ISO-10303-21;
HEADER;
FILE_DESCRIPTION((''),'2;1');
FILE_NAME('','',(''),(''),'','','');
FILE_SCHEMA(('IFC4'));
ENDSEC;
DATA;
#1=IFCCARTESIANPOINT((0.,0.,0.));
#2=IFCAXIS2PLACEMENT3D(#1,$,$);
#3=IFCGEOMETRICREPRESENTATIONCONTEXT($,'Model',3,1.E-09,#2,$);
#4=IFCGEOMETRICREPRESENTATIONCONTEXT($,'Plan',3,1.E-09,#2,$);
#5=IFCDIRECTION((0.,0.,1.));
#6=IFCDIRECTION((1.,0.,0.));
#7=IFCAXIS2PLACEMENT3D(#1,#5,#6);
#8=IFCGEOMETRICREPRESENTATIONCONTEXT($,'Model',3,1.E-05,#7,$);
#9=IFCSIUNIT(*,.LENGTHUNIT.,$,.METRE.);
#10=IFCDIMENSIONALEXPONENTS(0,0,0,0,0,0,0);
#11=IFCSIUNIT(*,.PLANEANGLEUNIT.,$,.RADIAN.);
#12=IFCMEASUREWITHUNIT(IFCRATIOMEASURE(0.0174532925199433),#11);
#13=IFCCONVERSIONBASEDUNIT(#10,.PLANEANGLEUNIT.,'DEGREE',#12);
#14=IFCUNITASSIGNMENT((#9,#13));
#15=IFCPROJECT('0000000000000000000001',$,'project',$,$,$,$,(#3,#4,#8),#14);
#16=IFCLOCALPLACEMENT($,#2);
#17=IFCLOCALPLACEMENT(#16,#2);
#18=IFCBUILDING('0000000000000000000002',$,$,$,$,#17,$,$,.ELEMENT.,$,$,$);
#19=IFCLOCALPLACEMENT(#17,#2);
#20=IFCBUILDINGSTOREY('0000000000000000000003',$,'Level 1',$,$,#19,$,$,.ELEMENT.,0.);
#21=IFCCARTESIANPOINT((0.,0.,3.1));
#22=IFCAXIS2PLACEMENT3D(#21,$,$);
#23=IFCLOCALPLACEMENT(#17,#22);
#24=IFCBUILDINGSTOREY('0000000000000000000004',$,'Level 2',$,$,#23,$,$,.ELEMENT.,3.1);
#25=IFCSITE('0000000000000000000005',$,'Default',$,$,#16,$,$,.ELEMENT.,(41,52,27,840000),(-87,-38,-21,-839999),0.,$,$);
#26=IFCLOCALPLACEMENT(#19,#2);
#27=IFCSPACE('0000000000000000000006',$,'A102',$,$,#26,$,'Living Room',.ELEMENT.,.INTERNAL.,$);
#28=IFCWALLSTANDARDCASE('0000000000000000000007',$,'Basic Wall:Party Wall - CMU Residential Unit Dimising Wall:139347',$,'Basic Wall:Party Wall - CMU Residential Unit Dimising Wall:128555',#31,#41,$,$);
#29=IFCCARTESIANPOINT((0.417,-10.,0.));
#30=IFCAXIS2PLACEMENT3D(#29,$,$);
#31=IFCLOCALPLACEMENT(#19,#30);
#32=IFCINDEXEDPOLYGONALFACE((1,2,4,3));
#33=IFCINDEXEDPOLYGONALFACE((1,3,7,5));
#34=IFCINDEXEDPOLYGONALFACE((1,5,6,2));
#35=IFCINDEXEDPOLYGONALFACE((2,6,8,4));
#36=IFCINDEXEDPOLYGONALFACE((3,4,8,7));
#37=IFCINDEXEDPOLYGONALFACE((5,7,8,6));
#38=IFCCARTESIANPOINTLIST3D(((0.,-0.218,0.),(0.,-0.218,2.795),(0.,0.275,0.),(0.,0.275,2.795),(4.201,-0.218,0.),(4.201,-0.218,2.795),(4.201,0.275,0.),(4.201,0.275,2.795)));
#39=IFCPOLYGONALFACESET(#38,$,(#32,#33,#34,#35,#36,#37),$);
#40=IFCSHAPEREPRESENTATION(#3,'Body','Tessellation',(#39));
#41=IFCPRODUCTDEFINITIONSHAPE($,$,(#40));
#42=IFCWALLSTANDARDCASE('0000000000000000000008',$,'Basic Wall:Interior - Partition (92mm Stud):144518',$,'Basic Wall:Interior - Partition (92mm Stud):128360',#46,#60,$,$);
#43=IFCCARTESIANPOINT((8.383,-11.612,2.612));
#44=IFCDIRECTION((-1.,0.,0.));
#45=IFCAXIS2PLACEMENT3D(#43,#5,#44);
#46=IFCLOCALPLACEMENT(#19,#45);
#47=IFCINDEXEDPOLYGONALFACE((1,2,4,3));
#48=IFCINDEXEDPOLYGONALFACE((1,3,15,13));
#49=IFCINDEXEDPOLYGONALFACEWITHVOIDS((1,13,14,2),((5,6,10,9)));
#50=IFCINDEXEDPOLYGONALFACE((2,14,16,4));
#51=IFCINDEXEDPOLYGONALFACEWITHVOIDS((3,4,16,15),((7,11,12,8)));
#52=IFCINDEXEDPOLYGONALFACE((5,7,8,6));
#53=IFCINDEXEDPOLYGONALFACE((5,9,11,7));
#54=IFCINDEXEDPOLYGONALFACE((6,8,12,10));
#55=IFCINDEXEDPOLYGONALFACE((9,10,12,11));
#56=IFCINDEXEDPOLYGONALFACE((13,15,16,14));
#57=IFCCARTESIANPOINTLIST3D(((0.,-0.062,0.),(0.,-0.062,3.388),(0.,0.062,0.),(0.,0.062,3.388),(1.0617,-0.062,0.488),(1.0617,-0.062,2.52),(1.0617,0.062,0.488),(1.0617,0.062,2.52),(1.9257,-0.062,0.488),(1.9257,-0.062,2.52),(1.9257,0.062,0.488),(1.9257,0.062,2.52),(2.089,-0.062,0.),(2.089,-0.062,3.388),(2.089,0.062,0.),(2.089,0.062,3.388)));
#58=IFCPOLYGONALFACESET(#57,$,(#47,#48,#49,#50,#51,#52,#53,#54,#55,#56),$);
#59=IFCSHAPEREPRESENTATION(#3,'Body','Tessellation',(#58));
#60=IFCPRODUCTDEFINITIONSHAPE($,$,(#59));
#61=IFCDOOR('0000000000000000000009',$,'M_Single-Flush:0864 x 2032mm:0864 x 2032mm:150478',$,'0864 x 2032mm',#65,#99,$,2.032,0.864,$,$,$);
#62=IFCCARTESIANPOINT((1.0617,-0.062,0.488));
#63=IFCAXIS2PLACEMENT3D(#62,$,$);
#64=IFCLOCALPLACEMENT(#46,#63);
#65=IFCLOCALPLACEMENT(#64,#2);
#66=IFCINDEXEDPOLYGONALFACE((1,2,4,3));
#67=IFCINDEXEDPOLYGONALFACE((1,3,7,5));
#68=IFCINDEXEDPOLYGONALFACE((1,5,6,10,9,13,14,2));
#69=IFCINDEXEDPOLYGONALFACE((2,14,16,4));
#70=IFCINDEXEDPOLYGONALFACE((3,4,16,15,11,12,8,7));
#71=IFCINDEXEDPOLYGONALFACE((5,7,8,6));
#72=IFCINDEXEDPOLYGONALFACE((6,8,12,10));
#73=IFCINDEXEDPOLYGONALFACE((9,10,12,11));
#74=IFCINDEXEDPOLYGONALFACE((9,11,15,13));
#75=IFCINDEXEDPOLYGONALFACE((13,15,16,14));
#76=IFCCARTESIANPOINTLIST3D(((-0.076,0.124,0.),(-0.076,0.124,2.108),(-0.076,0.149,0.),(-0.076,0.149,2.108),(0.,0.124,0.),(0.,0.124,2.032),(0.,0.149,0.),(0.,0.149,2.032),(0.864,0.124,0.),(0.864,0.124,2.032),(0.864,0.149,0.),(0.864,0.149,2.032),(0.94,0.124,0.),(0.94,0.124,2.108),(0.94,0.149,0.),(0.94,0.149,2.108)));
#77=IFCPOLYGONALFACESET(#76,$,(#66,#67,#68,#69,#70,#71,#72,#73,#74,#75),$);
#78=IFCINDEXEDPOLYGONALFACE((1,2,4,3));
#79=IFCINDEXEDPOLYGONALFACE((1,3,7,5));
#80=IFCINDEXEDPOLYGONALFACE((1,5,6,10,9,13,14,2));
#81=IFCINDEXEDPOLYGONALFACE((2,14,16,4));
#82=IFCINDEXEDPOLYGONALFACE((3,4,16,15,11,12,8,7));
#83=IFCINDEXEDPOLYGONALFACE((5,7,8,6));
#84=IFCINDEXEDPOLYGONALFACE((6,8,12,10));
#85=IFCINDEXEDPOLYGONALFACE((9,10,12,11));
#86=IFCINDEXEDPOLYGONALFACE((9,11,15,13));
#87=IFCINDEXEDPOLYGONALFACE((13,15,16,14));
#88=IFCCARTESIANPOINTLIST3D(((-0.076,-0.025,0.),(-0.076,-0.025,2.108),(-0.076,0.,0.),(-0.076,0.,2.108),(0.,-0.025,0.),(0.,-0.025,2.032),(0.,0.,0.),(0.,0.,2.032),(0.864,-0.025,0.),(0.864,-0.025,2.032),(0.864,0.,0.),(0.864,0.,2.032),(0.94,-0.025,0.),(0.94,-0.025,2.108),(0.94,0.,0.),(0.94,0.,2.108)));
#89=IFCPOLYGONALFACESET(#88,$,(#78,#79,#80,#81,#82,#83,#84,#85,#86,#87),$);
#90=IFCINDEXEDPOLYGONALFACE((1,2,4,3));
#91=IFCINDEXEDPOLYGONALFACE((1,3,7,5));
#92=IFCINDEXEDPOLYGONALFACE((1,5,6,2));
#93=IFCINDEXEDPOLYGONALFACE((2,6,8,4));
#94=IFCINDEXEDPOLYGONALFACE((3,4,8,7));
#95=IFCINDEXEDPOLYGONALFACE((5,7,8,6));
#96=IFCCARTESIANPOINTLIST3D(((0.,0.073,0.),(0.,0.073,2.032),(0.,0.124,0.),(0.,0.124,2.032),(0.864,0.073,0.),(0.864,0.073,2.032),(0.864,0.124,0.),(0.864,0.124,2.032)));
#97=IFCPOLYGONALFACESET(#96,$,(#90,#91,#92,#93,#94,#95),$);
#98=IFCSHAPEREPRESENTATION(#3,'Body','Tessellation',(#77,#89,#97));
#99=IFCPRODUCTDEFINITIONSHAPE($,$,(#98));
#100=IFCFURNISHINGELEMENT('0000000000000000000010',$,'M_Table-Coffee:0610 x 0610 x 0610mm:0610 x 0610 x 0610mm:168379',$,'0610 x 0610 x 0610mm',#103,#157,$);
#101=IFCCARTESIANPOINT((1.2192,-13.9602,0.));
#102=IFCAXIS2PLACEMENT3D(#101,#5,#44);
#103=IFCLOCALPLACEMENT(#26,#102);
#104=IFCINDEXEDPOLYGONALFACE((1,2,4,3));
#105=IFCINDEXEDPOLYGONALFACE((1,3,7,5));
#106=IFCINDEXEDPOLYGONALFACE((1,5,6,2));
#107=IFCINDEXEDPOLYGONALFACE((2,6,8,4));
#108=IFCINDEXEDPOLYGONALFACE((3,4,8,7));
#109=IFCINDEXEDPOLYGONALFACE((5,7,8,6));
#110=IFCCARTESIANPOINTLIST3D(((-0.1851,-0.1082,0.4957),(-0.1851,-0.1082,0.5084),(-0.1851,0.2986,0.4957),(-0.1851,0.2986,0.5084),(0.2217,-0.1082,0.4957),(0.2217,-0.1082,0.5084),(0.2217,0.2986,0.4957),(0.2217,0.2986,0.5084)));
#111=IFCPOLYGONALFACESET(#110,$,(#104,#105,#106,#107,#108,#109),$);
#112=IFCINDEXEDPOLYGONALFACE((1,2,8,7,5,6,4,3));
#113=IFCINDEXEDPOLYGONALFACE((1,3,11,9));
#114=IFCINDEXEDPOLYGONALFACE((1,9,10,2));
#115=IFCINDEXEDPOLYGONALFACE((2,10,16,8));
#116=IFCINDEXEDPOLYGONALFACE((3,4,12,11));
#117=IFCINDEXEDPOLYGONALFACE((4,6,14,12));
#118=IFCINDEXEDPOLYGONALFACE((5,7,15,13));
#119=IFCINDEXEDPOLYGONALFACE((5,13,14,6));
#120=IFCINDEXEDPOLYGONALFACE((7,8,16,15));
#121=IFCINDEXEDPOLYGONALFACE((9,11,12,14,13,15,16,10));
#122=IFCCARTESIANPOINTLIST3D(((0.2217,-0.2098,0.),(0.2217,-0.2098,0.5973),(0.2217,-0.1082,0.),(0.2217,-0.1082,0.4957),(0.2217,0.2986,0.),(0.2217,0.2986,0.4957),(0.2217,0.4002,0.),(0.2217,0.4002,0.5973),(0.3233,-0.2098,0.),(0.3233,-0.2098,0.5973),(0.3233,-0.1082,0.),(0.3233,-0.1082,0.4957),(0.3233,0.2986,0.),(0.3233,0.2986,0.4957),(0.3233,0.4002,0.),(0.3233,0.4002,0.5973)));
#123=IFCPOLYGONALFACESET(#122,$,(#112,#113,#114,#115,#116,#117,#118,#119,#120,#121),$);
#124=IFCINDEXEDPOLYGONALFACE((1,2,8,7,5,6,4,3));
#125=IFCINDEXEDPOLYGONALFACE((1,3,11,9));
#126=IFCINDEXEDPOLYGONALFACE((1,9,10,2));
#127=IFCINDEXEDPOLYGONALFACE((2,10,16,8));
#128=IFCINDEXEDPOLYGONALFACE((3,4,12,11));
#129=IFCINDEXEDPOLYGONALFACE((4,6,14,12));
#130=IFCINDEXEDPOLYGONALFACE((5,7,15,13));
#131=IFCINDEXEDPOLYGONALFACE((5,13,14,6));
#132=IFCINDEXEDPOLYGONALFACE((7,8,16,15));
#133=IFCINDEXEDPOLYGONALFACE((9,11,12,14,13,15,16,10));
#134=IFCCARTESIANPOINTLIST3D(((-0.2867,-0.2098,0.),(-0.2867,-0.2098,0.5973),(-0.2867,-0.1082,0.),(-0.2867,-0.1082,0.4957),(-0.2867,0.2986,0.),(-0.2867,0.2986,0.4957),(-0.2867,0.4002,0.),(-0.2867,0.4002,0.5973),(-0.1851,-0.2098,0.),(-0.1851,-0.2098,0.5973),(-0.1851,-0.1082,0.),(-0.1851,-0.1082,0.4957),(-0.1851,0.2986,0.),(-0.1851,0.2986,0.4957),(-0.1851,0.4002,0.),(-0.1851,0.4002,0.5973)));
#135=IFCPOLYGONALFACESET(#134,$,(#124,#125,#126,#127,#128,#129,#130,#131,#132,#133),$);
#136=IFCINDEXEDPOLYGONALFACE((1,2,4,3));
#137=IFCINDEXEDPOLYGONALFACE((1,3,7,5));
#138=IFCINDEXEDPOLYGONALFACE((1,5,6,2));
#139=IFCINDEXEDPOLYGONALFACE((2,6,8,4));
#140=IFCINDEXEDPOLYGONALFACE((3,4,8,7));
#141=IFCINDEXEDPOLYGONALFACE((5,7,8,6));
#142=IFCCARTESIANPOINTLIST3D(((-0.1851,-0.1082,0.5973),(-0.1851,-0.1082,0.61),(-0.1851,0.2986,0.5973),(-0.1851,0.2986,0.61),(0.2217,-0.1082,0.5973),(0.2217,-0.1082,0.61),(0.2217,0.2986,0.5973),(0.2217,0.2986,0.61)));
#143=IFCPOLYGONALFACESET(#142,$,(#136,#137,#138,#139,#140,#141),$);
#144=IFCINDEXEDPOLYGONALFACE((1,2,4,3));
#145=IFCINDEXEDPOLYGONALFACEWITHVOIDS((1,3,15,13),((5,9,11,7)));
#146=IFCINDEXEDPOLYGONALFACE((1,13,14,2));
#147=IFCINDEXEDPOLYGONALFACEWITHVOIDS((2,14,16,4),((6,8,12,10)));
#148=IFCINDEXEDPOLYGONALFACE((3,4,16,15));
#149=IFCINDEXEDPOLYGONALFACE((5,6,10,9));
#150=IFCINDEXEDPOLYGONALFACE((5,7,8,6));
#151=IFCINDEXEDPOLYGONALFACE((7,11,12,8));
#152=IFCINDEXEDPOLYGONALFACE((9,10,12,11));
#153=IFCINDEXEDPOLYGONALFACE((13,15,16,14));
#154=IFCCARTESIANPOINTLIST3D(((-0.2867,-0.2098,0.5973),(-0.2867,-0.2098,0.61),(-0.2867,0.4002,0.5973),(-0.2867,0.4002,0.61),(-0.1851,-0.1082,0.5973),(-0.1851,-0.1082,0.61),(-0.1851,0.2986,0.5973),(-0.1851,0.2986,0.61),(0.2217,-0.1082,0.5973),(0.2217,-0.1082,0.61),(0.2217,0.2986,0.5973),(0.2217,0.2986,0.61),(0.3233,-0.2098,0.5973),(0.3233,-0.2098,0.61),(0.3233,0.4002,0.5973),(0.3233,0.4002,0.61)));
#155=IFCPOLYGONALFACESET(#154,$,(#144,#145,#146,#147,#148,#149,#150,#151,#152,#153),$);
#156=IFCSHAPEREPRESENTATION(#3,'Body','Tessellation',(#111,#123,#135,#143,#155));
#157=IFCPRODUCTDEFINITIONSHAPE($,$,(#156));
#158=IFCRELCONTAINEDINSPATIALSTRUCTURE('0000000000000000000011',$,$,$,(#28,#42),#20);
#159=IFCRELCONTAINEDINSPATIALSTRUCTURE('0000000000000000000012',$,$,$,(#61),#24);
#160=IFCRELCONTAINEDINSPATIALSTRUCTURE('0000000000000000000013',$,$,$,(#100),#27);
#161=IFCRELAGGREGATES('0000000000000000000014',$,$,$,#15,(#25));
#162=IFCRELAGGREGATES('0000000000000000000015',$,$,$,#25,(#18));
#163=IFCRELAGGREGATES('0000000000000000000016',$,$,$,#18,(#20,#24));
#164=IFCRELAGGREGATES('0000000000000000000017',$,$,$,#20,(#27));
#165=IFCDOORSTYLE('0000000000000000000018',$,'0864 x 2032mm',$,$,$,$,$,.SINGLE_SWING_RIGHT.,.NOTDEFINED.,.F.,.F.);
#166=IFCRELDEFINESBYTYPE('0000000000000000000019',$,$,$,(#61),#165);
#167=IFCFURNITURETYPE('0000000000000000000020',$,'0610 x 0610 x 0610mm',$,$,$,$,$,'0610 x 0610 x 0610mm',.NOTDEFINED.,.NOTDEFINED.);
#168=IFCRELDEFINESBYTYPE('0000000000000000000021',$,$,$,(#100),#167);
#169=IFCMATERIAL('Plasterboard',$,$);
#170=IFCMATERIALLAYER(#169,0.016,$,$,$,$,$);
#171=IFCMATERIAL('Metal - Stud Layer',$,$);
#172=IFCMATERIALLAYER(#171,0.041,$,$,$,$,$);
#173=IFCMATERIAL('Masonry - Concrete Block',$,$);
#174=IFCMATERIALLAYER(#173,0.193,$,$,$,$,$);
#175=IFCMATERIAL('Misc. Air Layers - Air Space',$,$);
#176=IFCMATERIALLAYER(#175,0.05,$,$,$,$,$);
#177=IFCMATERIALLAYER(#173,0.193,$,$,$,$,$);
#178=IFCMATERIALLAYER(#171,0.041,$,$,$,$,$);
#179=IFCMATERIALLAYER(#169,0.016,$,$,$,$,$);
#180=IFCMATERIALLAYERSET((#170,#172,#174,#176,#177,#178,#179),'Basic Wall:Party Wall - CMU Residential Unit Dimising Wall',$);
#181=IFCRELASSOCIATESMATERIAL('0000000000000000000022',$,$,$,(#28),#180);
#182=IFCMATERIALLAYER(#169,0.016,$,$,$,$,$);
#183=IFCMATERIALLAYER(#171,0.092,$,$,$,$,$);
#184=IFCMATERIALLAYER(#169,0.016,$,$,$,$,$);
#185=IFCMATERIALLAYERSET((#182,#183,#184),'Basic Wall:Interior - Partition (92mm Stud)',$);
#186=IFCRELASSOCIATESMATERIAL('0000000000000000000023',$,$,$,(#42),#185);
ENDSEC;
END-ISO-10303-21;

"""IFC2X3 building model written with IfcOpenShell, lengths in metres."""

from ifc_helpers import new_model, entity, si_unit, converted_unit, frame, frame_2d, origin, origin_with_axes, origin_2d_with_axis, place, context, project, spatial, polyline, rectangle, outline, extrude, clip, bounded_halfspace, source, transform, mapped, material, layer, layer_set, layer_usage, type_object, type_shapes, element, fill, save


model = new_model("IFC2X3")

# Units and contexts
model_context_1 = context("Model", 3, precision=1e-09, world=origin())
plan_context = context("Plan", 3, precision=1e-09, world=origin())
model_context_2 = context("Model", 3, precision=1e-05, world=origin_with_axes())
ifc_project = project(units=[si_unit("LENGTHUNIT", "METRE"), converted_unit("PLANEANGLEUNIT", "DEGREE", entity("IfcRatioMeasure", 0.0174532925199433), si_unit("PLANEANGLEUNIT", "RADIAN"), dimensions=[0, 0, 0, 0, 0, 0, 0])], contexts=[model_context_1, plan_context, model_context_2])

# Site, building, storey
site_placement = place(None, origin())
site = spatial("IfcSite", under=ifc_project, at=site_placement, Name="Default", CompositionType="ELEMENT", RefLatitude=(41, 52, 27, 840000), RefLongitude=(-87, -38, -21, -839999), RefElevation=0.0)
building_placement = place(site_placement, origin())
building = spatial("IfcBuilding", under=site, at=building_placement, CompositionType="ELEMENT")
storey_1_placement = place(building_placement, origin())
storey_1 = spatial("IfcBuildingStorey", under=building, at=storey_1_placement, Name="Level 1", CompositionType="ELEMENT", Elevation=0.0)

# Shared definitions
ifc_material_1 = material(Name="Misc. Air Layers - Air Space")
ifc_material_2 = material(Name="Masonry - Concrete Block")
ifc_material_3 = material(Name="Metal - Stud Layer")
ifc_material_4 = material(Name="Plasterboard")

# Wall
ifc_layer_1 = layer(ifc_material_4, 0.016)
ifc_layer_2 = layer(ifc_material_3, 0.041)
ifc_layer_3 = layer(ifc_material_2, 0.193)
ifc_layer_4 = layer(ifc_material_1, 0.05)
ifc_layer_5 = layer(ifc_material_2, 0.193)
ifc_layer_6 = layer(ifc_material_3, 0.041)
ifc_layer_7 = layer(ifc_material_4, 0.016)
ifc_layer_set_1 = layer_set([ifc_layer_1, ifc_layer_2, ifc_layer_3, ifc_layer_4, ifc_layer_5, ifc_layer_6, ifc_layer_7], Name="Basic Wall:Party Wall - CMU Residential Unit Dimising Wall")
ifc_layer_usage_1 = layer_usage(ifc_layer_set_1, "AXIS2", "NEGATIVE", 0.275)
wall_1_placement = place(storey_1_placement, frame((0.417, -10.0, 0.0)))
element("IfcWallStandardCase", 1, at=wall_1_placement, inside=storey_1, material=ifc_layer_usage_1, Name="Basic Wall:Party Wall - CMU Residential Unit Dimising Wall:139347", ObjectType="Basic Wall:Party Wall - CMU Residential Unit Dimising Wall:128555", context=model_context_1, shape_type="Clipping", body=[
    clip(clip(extrude(rectangle(XDim=4.201, YDim=0.55, at=frame_2d((2.1005, 0.0), x_axis=(-1.0, 0.0))), origin(), (0.0, 0.0, 1.0), 2.795), bounded_halfspace(frame((0.0, -0.218, 0.0), z_axis=(0.0, 1.0, 0.0), x_axis=(-1.0, 0.0, 0.0)), True, frame((0.0, -0.218, 0.0), z_axis=(0.0, 1.0, 0.0), x_axis=(-1.0, 0.0, 0.0)), polyline([(0.0, 0.0), (0.0, 2.795), (-4.201, 2.795), (-4.201, 0.0), (0.0, 0.0)]))), bounded_halfspace(frame((4.201, 0.275, 0.0), z_axis=(-1.0, 0.0, 0.0), x_axis=(0.0, -1.0, 0.0)), True, frame((4.201, 0.275, 0.0), z_axis=(-1.0, 0.0, 0.0), x_axis=(0.0, -1.0, 0.0)), polyline([(0.0, 0.0), (0.493, 0.0), (0.493, 2.795), (0.0, 2.795), (0.0, 0.0)]))),
])

# Shared definitions
ifc_layer_8 = layer(ifc_material_4, 0.016)
ifc_layer_9 = layer(ifc_material_3, 0.092)
ifc_layer_10 = layer(ifc_material_4, 0.016)
ifc_layer_set_2 = layer_set([ifc_layer_8, ifc_layer_9, ifc_layer_10], Name="Basic Wall:Interior - Partition (92mm Stud)")

# Wall, opening
ifc_layer_usage_2 = layer_usage(ifc_layer_set_2, "AXIS2", "NEGATIVE", 0.062)
wall_2_placement = place(storey_1_placement, frame((8.383, -11.612, 2.612), z_axis=(0.0, 0.0, 1.0), x_axis=(-1.0, 0.0, 0.0)))
wall_2 = element("IfcWallStandardCase", 2, at=wall_2_placement, inside=storey_1, material=ifc_layer_usage_2, Name="Basic Wall:Interior - Partition (92mm Stud):144518", ObjectType="Basic Wall:Interior - Partition (92mm Stud):128360", context=model_context_1, shape_type="SweptSolid", body=[
    extrude(rectangle(XDim=2.089, YDim=0.124, at=frame_2d((1.0445, 0.0), x_axis=(-1.0, 0.0))), origin(), (0.0, 0.0, 1.0), 3.388),
])
opening_1_placement = place(wall_2_placement, frame((1.0617, -0.062, 0.488)))
opening_1 = element("IfcOpeningElement", 3, at=opening_1_placement, cuts=wall_2, ObjectType="Opening", context=model_context_1, shape_type="SweptSolid", body=[
    extrude(rectangle(XDim=0.864, YDim=2.032, at=frame_2d((1.016, 0.432), x_axis=(0.0, 1.0))), frame((0.0, 0.0, 0.0), z_axis=(0.0, 1.0, 0.0), x_axis=(0.0, 0.0, 1.0)), (0.0, 0.0, 1.0), 0.124),
])

# Shared definitions
storey_2_placement = place(building_placement, frame((0.0, 0.0, 3.1)))
storey_2 = spatial("IfcBuildingStorey", under=building, at=storey_2_placement, Name="Level 2", CompositionType="ELEMENT", Elevation=3.1)

# Door
door_style_1 = type_object("IfcDoorStyle", Name="0864 x 2032mm", ConstructionType="NOTDEFINED", OperationType="SINGLE_SWING_RIGHT", ParameterTakesPrecedence=False, Sizeable=False)
shared_shape_1 = source(origin(), model_context_1, "Body", "SweptSolid", [
    extrude(outline(polyline([(-0.508, -1.073), (0.508, -1.073), (0.508, 1.035), (0.432, 1.035), (0.432, -0.997), (-0.432, -0.997), (-0.432, 1.035), (-0.508, 1.035), (-0.508, -1.073)])), frame((0.432, 0.124, 1.035), z_axis=(0.0, 1.0, 0.0), x_axis=(1.0, 0.0, 0.0)), (0.0, 0.0, 1.0), 0.025),
    extrude(outline(polyline([(-1.073, -0.508), (1.035, -0.508), (1.035, -0.432), (-0.997, -0.432), (-0.997, 0.432), (1.035, 0.432), (1.035, 0.508), (-1.073, 0.508), (-1.073, -0.508)])), frame((0.432, -0.025, 1.035), z_axis=(0.0, 1.0, 0.0), x_axis=(0.0, 0.0, -1.0)), (0.0, 0.0, 1.0), 0.025),
    extrude(rectangle(XDim=0.051, YDim=0.864, at=origin_2d_with_axis()), frame((0.432, 0.0985, 0.0), z_axis=(0.0, 0.0, 1.0), x_axis=(0.0, 1.0, 0.0)), (0.0, 0.0, 1.0), 2.032),
])
type_shapes(door_style_1, [shared_shape_1])
door_1_placement = place(opening_1_placement, origin())
door_1 = element("IfcDoor", 4, at=door_1_placement, inside=storey_2, type_object=door_style_1, Name="M_Single-Flush:0864 x 2032mm:0864 x 2032mm:150478", ObjectType="0864 x 2032mm", OverallHeight=2.032, OverallWidth=0.864, context=model_context_1, shape_type="MappedRepresentation", body=[
    mapped(shared_shape_1, transform((0.0, 0.0, 0.0), scale=1.0)),
])
fill(opening_1, door_1)

# Shared definitions
space_1_placement = place(storey_1_placement, origin())
space_1 = spatial("IfcSpace", under=storey_1, at=space_1_placement, Name="A102", LongName="Living Room", CompositionType="ELEMENT", InteriorOrExteriorSpace="INTERNAL")

# Furnishing element
furniture_type_1 = type_object("IfcFurnitureType", Name="0610 x 0610 x 0610mm", ElementType="0610 x 0610 x 0610mm", AssemblyPlace="NOTDEFINED")
shared_shape_2 = source(origin(), model_context_1, "Body", "SweptSolid", [
    extrude(rectangle(XDim=0.4068, YDim=0.4068, at=origin_2d_with_axis()), frame((0.0183, 0.0952, 0.4957), z_axis=(0.0, 0.0, 1.0), x_axis=(-1.0, 0.0, 0.0)), (0.0, 0.0, 1.0), 0.0127),
    extrude(outline(polyline([(-0.2732, -0.305), (0.324, -0.305), (0.324, 0.305), (-0.2732, 0.305), (-0.2732, 0.2034), (0.2225, 0.2034), (0.2225, -0.2034), (-0.2732, -0.2034), (-0.2732, -0.305)])), frame((0.2217, 0.0952, 0.2732), z_axis=(1.0, 0.0, 0.0), x_axis=(0.0, 0.0, 1.0)), (0.0, 0.0, 1.0), 0.1016),
    extrude(outline(polyline([(-0.305, -0.3241), (0.305, -0.3241), (0.305, 0.2733), (0.2034, 0.2733), (0.2034, -0.2224), (-0.2034, -0.2224), (-0.2034, 0.2733), (-0.305, 0.2733), (-0.305, -0.3241)])), frame((-0.2867, 0.0952, 0.2733), z_axis=(1.0, 0.0, 0.0), x_axis=(0.0, -1.0, 0.0)), (0.0, 0.0, 1.0), 0.1016),
    extrude(rectangle(XDim=0.4068, YDim=0.4068, at=origin_2d_with_axis()), frame((0.0183, 0.0952, 0.5973), z_axis=(0.0, 0.0, 1.0), x_axis=(-1.0, 0.0, 0.0)), (0.0, 0.0, 1.0), 0.0127),
    extrude(outline(polyline([(-0.305, -0.305), (0.305, -0.305), (0.305, 0.305), (-0.305, 0.305), (-0.305, -0.305)]), holes=[polyline([(-0.2034, -0.2034), (-0.2034, 0.2034), (0.2034, 0.2034), (0.2034, -0.2034), (-0.2034, -0.2034)])]), frame((0.0183, 0.0952, 0.5973), z_axis=(0.0, 0.0, 1.0), x_axis=(-1.0, 0.0, 0.0)), (0.0, 0.0, 1.0), 0.0127),
])
type_shapes(furniture_type_1, [shared_shape_2])
for number, where, z_axis, x_axis, name in (
    (5, (1.2192, -13.9602, 0.0), (0.0, 0.0, 1.0), (-1.0, 0.0, 0.0), "M_Table-Coffee:0610 x 0610 x 0610mm:0610 x 0610 x 0610mm:168379"),
):
    element("IfcFurnishingElement", number, at=place(space_1_placement, frame(where, z_axis=z_axis, x_axis=x_axis)), inside=space_1, type_object=furniture_type_1, Name=name, ObjectType="0610 x 0610 x 0610mm", context=model_context_1, shape_type="MappedRepresentation", body=[
        mapped(shared_shape_2, transform((0.0, 0.0, 0.0), scale=1.0)),
    ])

save(model, "model.ifc")
